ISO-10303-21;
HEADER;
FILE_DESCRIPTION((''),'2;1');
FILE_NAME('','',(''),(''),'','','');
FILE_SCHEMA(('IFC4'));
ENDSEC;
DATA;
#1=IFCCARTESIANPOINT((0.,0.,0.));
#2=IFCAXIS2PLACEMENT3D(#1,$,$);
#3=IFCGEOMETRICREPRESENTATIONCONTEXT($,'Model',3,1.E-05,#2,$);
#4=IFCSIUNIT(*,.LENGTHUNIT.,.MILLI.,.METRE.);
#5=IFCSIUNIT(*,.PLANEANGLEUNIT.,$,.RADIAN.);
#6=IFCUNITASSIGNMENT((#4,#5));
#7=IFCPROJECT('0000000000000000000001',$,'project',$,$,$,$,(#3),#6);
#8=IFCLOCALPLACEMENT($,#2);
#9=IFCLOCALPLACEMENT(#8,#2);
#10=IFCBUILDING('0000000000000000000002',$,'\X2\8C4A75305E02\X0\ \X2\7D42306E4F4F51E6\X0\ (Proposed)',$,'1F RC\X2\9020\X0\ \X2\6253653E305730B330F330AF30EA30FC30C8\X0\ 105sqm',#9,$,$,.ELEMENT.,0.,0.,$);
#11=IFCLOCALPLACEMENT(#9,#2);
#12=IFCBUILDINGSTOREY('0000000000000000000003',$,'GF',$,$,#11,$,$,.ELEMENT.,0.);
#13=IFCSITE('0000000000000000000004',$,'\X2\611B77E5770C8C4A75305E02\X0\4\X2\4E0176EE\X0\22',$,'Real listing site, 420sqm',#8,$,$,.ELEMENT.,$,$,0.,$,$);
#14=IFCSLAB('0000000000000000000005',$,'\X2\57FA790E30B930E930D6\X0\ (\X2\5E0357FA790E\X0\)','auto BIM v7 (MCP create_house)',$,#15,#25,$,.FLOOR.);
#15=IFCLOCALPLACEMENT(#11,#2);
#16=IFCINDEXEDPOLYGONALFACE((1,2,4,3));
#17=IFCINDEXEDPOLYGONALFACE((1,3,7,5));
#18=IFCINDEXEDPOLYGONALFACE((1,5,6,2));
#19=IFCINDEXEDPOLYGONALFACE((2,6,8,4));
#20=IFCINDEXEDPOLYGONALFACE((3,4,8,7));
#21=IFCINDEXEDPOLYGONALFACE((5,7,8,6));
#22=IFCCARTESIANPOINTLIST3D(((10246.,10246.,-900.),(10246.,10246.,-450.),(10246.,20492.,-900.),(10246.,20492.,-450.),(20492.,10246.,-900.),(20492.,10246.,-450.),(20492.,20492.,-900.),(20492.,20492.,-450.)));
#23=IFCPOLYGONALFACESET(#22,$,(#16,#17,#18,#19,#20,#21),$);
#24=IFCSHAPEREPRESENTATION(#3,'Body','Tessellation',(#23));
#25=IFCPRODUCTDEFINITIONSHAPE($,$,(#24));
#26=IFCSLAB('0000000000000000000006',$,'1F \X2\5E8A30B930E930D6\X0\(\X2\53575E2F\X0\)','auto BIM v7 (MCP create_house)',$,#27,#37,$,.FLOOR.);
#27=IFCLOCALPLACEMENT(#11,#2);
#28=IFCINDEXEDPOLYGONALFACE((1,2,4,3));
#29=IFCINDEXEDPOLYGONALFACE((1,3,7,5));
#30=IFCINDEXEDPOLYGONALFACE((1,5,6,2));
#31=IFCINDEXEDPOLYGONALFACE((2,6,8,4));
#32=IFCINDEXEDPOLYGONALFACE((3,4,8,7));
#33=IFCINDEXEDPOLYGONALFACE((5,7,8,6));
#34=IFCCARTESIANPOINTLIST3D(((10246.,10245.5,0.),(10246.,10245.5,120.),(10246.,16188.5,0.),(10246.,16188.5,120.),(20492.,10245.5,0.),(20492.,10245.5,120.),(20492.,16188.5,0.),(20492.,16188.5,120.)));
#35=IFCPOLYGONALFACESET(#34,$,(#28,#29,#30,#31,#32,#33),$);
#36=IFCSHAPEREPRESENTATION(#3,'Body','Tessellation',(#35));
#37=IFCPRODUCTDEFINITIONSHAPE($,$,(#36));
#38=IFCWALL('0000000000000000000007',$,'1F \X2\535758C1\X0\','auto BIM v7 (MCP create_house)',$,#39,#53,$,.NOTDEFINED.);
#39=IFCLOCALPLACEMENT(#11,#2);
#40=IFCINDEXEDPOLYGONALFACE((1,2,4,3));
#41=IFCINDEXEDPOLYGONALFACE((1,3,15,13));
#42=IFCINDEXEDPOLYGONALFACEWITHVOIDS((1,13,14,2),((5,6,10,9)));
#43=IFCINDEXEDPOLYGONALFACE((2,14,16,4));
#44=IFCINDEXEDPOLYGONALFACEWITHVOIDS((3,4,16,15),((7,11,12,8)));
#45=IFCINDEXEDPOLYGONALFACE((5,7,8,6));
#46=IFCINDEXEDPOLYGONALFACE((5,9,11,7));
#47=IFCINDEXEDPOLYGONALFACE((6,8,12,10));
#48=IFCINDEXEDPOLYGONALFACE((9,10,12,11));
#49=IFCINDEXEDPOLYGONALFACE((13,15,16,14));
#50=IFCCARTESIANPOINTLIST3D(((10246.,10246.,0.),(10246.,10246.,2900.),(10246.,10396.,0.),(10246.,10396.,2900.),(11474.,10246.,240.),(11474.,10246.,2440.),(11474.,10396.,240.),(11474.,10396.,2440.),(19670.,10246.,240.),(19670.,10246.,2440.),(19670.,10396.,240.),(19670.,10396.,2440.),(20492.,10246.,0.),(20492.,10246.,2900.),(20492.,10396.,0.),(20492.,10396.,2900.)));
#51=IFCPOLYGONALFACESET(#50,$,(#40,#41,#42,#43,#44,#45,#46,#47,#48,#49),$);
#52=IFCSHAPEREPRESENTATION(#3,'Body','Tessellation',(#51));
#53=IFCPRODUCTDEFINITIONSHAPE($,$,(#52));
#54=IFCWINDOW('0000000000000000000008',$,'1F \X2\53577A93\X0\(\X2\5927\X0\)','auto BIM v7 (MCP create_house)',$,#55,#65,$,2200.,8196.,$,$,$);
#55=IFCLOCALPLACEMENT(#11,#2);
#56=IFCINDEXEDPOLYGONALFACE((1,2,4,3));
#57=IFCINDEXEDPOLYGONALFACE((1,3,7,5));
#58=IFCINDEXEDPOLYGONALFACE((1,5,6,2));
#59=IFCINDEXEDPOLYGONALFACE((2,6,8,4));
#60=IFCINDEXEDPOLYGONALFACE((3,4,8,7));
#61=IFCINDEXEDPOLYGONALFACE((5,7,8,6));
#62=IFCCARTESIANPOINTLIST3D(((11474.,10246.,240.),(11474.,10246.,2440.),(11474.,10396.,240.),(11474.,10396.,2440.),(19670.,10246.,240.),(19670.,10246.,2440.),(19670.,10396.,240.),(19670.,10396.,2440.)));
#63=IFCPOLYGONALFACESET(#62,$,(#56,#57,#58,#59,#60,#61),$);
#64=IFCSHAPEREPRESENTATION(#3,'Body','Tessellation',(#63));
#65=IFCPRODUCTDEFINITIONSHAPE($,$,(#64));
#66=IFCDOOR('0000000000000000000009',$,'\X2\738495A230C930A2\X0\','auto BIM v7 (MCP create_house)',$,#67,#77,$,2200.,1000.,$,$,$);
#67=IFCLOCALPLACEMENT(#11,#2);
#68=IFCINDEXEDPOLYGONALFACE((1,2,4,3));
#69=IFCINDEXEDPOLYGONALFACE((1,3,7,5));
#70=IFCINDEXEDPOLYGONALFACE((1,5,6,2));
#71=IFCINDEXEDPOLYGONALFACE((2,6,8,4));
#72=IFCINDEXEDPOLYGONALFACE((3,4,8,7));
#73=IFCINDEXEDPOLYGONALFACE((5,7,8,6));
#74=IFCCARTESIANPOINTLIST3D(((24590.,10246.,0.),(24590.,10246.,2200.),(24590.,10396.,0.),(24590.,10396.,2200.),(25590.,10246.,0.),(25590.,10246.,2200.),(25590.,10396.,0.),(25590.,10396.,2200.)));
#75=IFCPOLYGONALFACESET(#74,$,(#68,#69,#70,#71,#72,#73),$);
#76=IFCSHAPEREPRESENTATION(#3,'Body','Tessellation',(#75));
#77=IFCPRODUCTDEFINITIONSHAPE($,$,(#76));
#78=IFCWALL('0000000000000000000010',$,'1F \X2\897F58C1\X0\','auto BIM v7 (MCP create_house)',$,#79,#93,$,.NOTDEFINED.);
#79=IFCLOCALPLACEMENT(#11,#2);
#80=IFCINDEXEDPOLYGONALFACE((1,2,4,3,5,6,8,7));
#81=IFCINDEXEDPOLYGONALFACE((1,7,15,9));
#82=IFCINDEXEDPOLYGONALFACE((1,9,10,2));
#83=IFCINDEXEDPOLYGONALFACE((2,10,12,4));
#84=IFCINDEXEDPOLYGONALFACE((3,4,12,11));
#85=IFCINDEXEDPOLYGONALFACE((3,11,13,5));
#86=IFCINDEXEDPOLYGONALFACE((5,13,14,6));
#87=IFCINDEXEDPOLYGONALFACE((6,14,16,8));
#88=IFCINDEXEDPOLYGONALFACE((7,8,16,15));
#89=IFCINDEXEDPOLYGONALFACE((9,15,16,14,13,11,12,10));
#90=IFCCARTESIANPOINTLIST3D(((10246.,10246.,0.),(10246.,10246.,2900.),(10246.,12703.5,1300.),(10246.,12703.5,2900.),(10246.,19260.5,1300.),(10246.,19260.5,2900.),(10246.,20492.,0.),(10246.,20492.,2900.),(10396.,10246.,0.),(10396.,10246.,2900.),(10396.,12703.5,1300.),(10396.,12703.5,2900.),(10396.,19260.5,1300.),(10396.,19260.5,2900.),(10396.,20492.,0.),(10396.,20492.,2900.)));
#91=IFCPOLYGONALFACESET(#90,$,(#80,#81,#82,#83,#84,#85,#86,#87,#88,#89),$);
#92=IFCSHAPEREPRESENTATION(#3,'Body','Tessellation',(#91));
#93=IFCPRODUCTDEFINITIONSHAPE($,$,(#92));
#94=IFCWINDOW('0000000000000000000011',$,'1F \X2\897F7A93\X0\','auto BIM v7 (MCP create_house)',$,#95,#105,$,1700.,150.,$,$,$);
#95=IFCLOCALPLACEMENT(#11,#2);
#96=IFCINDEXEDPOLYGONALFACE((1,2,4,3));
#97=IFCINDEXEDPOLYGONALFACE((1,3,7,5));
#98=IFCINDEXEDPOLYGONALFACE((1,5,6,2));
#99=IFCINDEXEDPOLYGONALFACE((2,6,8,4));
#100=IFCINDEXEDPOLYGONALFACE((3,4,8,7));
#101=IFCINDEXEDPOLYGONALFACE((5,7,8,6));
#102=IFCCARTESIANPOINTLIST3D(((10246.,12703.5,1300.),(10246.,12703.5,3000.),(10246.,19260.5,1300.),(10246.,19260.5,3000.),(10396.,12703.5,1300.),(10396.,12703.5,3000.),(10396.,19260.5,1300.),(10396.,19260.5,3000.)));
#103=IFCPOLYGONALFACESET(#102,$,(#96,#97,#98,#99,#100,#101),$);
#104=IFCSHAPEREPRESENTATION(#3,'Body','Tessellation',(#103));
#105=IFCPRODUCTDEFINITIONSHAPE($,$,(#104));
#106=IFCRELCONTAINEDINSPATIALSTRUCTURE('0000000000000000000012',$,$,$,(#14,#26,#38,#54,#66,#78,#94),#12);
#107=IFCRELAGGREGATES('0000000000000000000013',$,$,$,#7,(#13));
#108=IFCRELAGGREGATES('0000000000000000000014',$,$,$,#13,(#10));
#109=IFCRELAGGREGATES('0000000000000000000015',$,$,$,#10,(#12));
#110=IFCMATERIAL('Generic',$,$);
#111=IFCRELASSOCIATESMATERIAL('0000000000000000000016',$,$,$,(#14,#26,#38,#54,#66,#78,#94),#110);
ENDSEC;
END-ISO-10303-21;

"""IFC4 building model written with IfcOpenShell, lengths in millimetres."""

from ifc_helpers import new_model, si_unit, frame, frame_2d, origin, place, context, project, spatial, rectangle, extrude, material, element, fill, save


model = new_model("IFC4")

# Units and contexts
model_context = context("Model", 3, precision=1e-05, world=origin())
ifc_project = project(units=[si_unit("LENGTHUNIT", "METRE", prefix="MILLI"), si_unit("PLANEANGLEUNIT", "RADIAN")], contexts=[model_context])

# Site, building, storey
site_placement = place(None, origin())
site = spatial("IfcSite", under=ifc_project, at=site_placement, Name="愛知県豊田市4丁目22", ObjectType="Real listing site, 420sqm", CompositionType="ELEMENT", RefElevation=0.0)
building_placement = place(site_placement, origin())
building = spatial("IfcBuilding", under=site, at=building_placement, Name="豊田市 終の住処 (Proposed)", ObjectType="1F RC造 打放しコンクリート 105sqm", CompositionType="ELEMENT", ElevationOfRefHeight=0.0, ElevationOfTerrain=0.0)
storey_placement = place(building_placement, origin())
storey = spatial("IfcBuildingStorey", under=building, at=storey_placement, Name="GF", CompositionType="ELEMENT", Elevation=0.0)

# Slabs
ifc_material = material(Name="Generic")
slab_1_placement = place(storey_placement, frame((5123.0, 5123.0, -450.0)))
element("IfcSlab", 1, at=slab_1_placement, inside=storey, material=ifc_material, Name="基礎スラブ (布基礎)", Description="auto BIM v7 (MCP create_house)", PredefinedType="FLOOR", context=model_context, shape_type="SweptSolid", body=[
    extrude(rectangle(XDim=10246.0, YDim=10246.0, at=frame_2d((5123.0, 5123.0))), frame((5123.0, 5123.0, -450.0)), (0.0, 0.0, 1.0), 450.0),
])
slab_2_placement = place(storey_placement, frame((5123.0, 5123.0, 0.0)))
element("IfcSlab", 2, at=slab_2_placement, inside=storey, material=ifc_material, Name="1F 床スラブ(南帯)", Description="auto BIM v7 (MCP create_house)", PredefinedType="FLOOR", context=model_context, shape_type="SweptSolid", body=[
    extrude(rectangle(XDim=10246.0, YDim=5943.0, at=frame_2d((5123.0, 2971.0))), frame((5123.0, 5123.0, 0.0)), (0.0, 0.0, 1.0), 120.0),
])

# Wall, openings, window, door
wall_1_placement = place(storey_placement, frame((5123.0, 5123.0, 0.0)))
wall_1 = element("IfcWall", 3, at=wall_1_placement, inside=storey, material=ifc_material, Name="1F 南壁", Description="auto BIM v7 (MCP create_house)", PredefinedType="NOTDEFINED", context=model_context, shape_type="SweptSolid", body=[
    extrude(rectangle(XDim=10246.0, YDim=150.0, at=frame_2d((5123.0, 75.0))), frame((5123.0, 5123.0, 0.0)), (0.0, 0.0, 1.0), 2900.0),
])
opening_1_placement = place(storey_placement, frame((5737.0, 5123.0, 120.0)))
opening_1 = element("IfcOpeningElement", 4, at=opening_1_placement, cuts=wall_1, PredefinedType="NOTDEFINED", context=model_context, shape_type="SweptSolid", body=[
    extrude(rectangle(XDim=8196.0, YDim=150.0, at=frame_2d((4098.0, 75.0))), frame((5737.0, 5123.0, 120.0)), (0.0, 0.0, 1.0), 2200.0),
])
opening_2_placement = place(storey_placement, frame((12295.0, 5123.0, 0.0)))
opening_2 = element("IfcOpeningElement", 5, at=opening_2_placement, cuts=wall_1, PredefinedType="NOTDEFINED", context=model_context, shape_type="SweptSolid", body=[
    extrude(rectangle(XDim=1000.0, YDim=150.0, at=frame_2d((500.0, 75.0))), frame((12295.0, 5123.0, 0.0)), (0.0, 0.0, 1.0), 2200.0),
])
window_1_placement = place(storey_placement, frame((5737.0, 5123.0, 120.0)))
window_1 = element("IfcWindow", 6, at=window_1_placement, inside=storey, material=ifc_material, Name="1F 南窓(大)", Description="auto BIM v7 (MCP create_house)", OverallHeight=2200.0, OverallWidth=8196.0, context=model_context, shape_type="SweptSolid", body=[
    extrude(rectangle(XDim=8196.0, YDim=150.0, at=frame_2d((4098.0, 75.0))), frame((5737.0, 5123.0, 120.0)), (0.0, 0.0, 1.0), 2200.0),
])
fill(opening_1, window_1)
door_placement = place(storey_placement, frame((12295.0, 5123.0, 0.0)))
door = element("IfcDoor", 7, at=door_placement, inside=storey, material=ifc_material, Name="玄関ドア", Description="auto BIM v7 (MCP create_house)", OverallHeight=2200.0, OverallWidth=1000.0, context=model_context, shape_type="SweptSolid", body=[
    extrude(rectangle(XDim=1000.0, YDim=150.0, at=frame_2d((500.0, 75.0))), frame((12295.0, 5123.0, 0.0)), (0.0, 0.0, 1.0), 2200.0),
])
fill(opening_2, door)

# Wall, opening, window
wall_2_placement = place(storey_placement, frame((5123.0, 5123.0, 0.0)))
wall_2 = element("IfcWall", 8, at=wall_2_placement, inside=storey, material=ifc_material, Name="1F 西壁", Description="auto BIM v7 (MCP create_house)", PredefinedType="NOTDEFINED", context=model_context, shape_type="SweptSolid", body=[
    extrude(rectangle(XDim=150.0, YDim=10246.0, at=frame_2d((75.0, 5123.0))), frame((5123.0, 5123.0, 0.0)), (0.0, 0.0, 1.0), 2900.0),
])
opening_3_placement = place(storey_placement, frame((5123.0, 6352.0, 650.0)))
opening_3 = element("IfcOpeningElement", 9, at=opening_3_placement, cuts=wall_2, PredefinedType="NOTDEFINED", context=model_context, shape_type="SweptSolid", body=[
    extrude(rectangle(XDim=150.0, YDim=6557.0, at=frame_2d((75.0, 3278.0))), frame((5123.0, 6352.0, 650.0)), (0.0, 0.0, 1.0), 1700.0),
])
window_2_placement = place(storey_placement, frame((5123.0, 6352.0, 650.0)))
window_2 = element("IfcWindow", 10, at=window_2_placement, inside=storey, material=ifc_material, Name="1F 西窓", Description="auto BIM v7 (MCP create_house)", OverallHeight=1700.0, OverallWidth=150.0, context=model_context, shape_type="SweptSolid", body=[
    extrude(rectangle(XDim=150.0, YDim=6557.0, at=frame_2d((75.0, 3278.0))), frame((5123.0, 6352.0, 650.0)), (0.0, 0.0, 1.0), 1700.0),
])
fill(opening_3, window_2)

save(model, "model.ifc")
